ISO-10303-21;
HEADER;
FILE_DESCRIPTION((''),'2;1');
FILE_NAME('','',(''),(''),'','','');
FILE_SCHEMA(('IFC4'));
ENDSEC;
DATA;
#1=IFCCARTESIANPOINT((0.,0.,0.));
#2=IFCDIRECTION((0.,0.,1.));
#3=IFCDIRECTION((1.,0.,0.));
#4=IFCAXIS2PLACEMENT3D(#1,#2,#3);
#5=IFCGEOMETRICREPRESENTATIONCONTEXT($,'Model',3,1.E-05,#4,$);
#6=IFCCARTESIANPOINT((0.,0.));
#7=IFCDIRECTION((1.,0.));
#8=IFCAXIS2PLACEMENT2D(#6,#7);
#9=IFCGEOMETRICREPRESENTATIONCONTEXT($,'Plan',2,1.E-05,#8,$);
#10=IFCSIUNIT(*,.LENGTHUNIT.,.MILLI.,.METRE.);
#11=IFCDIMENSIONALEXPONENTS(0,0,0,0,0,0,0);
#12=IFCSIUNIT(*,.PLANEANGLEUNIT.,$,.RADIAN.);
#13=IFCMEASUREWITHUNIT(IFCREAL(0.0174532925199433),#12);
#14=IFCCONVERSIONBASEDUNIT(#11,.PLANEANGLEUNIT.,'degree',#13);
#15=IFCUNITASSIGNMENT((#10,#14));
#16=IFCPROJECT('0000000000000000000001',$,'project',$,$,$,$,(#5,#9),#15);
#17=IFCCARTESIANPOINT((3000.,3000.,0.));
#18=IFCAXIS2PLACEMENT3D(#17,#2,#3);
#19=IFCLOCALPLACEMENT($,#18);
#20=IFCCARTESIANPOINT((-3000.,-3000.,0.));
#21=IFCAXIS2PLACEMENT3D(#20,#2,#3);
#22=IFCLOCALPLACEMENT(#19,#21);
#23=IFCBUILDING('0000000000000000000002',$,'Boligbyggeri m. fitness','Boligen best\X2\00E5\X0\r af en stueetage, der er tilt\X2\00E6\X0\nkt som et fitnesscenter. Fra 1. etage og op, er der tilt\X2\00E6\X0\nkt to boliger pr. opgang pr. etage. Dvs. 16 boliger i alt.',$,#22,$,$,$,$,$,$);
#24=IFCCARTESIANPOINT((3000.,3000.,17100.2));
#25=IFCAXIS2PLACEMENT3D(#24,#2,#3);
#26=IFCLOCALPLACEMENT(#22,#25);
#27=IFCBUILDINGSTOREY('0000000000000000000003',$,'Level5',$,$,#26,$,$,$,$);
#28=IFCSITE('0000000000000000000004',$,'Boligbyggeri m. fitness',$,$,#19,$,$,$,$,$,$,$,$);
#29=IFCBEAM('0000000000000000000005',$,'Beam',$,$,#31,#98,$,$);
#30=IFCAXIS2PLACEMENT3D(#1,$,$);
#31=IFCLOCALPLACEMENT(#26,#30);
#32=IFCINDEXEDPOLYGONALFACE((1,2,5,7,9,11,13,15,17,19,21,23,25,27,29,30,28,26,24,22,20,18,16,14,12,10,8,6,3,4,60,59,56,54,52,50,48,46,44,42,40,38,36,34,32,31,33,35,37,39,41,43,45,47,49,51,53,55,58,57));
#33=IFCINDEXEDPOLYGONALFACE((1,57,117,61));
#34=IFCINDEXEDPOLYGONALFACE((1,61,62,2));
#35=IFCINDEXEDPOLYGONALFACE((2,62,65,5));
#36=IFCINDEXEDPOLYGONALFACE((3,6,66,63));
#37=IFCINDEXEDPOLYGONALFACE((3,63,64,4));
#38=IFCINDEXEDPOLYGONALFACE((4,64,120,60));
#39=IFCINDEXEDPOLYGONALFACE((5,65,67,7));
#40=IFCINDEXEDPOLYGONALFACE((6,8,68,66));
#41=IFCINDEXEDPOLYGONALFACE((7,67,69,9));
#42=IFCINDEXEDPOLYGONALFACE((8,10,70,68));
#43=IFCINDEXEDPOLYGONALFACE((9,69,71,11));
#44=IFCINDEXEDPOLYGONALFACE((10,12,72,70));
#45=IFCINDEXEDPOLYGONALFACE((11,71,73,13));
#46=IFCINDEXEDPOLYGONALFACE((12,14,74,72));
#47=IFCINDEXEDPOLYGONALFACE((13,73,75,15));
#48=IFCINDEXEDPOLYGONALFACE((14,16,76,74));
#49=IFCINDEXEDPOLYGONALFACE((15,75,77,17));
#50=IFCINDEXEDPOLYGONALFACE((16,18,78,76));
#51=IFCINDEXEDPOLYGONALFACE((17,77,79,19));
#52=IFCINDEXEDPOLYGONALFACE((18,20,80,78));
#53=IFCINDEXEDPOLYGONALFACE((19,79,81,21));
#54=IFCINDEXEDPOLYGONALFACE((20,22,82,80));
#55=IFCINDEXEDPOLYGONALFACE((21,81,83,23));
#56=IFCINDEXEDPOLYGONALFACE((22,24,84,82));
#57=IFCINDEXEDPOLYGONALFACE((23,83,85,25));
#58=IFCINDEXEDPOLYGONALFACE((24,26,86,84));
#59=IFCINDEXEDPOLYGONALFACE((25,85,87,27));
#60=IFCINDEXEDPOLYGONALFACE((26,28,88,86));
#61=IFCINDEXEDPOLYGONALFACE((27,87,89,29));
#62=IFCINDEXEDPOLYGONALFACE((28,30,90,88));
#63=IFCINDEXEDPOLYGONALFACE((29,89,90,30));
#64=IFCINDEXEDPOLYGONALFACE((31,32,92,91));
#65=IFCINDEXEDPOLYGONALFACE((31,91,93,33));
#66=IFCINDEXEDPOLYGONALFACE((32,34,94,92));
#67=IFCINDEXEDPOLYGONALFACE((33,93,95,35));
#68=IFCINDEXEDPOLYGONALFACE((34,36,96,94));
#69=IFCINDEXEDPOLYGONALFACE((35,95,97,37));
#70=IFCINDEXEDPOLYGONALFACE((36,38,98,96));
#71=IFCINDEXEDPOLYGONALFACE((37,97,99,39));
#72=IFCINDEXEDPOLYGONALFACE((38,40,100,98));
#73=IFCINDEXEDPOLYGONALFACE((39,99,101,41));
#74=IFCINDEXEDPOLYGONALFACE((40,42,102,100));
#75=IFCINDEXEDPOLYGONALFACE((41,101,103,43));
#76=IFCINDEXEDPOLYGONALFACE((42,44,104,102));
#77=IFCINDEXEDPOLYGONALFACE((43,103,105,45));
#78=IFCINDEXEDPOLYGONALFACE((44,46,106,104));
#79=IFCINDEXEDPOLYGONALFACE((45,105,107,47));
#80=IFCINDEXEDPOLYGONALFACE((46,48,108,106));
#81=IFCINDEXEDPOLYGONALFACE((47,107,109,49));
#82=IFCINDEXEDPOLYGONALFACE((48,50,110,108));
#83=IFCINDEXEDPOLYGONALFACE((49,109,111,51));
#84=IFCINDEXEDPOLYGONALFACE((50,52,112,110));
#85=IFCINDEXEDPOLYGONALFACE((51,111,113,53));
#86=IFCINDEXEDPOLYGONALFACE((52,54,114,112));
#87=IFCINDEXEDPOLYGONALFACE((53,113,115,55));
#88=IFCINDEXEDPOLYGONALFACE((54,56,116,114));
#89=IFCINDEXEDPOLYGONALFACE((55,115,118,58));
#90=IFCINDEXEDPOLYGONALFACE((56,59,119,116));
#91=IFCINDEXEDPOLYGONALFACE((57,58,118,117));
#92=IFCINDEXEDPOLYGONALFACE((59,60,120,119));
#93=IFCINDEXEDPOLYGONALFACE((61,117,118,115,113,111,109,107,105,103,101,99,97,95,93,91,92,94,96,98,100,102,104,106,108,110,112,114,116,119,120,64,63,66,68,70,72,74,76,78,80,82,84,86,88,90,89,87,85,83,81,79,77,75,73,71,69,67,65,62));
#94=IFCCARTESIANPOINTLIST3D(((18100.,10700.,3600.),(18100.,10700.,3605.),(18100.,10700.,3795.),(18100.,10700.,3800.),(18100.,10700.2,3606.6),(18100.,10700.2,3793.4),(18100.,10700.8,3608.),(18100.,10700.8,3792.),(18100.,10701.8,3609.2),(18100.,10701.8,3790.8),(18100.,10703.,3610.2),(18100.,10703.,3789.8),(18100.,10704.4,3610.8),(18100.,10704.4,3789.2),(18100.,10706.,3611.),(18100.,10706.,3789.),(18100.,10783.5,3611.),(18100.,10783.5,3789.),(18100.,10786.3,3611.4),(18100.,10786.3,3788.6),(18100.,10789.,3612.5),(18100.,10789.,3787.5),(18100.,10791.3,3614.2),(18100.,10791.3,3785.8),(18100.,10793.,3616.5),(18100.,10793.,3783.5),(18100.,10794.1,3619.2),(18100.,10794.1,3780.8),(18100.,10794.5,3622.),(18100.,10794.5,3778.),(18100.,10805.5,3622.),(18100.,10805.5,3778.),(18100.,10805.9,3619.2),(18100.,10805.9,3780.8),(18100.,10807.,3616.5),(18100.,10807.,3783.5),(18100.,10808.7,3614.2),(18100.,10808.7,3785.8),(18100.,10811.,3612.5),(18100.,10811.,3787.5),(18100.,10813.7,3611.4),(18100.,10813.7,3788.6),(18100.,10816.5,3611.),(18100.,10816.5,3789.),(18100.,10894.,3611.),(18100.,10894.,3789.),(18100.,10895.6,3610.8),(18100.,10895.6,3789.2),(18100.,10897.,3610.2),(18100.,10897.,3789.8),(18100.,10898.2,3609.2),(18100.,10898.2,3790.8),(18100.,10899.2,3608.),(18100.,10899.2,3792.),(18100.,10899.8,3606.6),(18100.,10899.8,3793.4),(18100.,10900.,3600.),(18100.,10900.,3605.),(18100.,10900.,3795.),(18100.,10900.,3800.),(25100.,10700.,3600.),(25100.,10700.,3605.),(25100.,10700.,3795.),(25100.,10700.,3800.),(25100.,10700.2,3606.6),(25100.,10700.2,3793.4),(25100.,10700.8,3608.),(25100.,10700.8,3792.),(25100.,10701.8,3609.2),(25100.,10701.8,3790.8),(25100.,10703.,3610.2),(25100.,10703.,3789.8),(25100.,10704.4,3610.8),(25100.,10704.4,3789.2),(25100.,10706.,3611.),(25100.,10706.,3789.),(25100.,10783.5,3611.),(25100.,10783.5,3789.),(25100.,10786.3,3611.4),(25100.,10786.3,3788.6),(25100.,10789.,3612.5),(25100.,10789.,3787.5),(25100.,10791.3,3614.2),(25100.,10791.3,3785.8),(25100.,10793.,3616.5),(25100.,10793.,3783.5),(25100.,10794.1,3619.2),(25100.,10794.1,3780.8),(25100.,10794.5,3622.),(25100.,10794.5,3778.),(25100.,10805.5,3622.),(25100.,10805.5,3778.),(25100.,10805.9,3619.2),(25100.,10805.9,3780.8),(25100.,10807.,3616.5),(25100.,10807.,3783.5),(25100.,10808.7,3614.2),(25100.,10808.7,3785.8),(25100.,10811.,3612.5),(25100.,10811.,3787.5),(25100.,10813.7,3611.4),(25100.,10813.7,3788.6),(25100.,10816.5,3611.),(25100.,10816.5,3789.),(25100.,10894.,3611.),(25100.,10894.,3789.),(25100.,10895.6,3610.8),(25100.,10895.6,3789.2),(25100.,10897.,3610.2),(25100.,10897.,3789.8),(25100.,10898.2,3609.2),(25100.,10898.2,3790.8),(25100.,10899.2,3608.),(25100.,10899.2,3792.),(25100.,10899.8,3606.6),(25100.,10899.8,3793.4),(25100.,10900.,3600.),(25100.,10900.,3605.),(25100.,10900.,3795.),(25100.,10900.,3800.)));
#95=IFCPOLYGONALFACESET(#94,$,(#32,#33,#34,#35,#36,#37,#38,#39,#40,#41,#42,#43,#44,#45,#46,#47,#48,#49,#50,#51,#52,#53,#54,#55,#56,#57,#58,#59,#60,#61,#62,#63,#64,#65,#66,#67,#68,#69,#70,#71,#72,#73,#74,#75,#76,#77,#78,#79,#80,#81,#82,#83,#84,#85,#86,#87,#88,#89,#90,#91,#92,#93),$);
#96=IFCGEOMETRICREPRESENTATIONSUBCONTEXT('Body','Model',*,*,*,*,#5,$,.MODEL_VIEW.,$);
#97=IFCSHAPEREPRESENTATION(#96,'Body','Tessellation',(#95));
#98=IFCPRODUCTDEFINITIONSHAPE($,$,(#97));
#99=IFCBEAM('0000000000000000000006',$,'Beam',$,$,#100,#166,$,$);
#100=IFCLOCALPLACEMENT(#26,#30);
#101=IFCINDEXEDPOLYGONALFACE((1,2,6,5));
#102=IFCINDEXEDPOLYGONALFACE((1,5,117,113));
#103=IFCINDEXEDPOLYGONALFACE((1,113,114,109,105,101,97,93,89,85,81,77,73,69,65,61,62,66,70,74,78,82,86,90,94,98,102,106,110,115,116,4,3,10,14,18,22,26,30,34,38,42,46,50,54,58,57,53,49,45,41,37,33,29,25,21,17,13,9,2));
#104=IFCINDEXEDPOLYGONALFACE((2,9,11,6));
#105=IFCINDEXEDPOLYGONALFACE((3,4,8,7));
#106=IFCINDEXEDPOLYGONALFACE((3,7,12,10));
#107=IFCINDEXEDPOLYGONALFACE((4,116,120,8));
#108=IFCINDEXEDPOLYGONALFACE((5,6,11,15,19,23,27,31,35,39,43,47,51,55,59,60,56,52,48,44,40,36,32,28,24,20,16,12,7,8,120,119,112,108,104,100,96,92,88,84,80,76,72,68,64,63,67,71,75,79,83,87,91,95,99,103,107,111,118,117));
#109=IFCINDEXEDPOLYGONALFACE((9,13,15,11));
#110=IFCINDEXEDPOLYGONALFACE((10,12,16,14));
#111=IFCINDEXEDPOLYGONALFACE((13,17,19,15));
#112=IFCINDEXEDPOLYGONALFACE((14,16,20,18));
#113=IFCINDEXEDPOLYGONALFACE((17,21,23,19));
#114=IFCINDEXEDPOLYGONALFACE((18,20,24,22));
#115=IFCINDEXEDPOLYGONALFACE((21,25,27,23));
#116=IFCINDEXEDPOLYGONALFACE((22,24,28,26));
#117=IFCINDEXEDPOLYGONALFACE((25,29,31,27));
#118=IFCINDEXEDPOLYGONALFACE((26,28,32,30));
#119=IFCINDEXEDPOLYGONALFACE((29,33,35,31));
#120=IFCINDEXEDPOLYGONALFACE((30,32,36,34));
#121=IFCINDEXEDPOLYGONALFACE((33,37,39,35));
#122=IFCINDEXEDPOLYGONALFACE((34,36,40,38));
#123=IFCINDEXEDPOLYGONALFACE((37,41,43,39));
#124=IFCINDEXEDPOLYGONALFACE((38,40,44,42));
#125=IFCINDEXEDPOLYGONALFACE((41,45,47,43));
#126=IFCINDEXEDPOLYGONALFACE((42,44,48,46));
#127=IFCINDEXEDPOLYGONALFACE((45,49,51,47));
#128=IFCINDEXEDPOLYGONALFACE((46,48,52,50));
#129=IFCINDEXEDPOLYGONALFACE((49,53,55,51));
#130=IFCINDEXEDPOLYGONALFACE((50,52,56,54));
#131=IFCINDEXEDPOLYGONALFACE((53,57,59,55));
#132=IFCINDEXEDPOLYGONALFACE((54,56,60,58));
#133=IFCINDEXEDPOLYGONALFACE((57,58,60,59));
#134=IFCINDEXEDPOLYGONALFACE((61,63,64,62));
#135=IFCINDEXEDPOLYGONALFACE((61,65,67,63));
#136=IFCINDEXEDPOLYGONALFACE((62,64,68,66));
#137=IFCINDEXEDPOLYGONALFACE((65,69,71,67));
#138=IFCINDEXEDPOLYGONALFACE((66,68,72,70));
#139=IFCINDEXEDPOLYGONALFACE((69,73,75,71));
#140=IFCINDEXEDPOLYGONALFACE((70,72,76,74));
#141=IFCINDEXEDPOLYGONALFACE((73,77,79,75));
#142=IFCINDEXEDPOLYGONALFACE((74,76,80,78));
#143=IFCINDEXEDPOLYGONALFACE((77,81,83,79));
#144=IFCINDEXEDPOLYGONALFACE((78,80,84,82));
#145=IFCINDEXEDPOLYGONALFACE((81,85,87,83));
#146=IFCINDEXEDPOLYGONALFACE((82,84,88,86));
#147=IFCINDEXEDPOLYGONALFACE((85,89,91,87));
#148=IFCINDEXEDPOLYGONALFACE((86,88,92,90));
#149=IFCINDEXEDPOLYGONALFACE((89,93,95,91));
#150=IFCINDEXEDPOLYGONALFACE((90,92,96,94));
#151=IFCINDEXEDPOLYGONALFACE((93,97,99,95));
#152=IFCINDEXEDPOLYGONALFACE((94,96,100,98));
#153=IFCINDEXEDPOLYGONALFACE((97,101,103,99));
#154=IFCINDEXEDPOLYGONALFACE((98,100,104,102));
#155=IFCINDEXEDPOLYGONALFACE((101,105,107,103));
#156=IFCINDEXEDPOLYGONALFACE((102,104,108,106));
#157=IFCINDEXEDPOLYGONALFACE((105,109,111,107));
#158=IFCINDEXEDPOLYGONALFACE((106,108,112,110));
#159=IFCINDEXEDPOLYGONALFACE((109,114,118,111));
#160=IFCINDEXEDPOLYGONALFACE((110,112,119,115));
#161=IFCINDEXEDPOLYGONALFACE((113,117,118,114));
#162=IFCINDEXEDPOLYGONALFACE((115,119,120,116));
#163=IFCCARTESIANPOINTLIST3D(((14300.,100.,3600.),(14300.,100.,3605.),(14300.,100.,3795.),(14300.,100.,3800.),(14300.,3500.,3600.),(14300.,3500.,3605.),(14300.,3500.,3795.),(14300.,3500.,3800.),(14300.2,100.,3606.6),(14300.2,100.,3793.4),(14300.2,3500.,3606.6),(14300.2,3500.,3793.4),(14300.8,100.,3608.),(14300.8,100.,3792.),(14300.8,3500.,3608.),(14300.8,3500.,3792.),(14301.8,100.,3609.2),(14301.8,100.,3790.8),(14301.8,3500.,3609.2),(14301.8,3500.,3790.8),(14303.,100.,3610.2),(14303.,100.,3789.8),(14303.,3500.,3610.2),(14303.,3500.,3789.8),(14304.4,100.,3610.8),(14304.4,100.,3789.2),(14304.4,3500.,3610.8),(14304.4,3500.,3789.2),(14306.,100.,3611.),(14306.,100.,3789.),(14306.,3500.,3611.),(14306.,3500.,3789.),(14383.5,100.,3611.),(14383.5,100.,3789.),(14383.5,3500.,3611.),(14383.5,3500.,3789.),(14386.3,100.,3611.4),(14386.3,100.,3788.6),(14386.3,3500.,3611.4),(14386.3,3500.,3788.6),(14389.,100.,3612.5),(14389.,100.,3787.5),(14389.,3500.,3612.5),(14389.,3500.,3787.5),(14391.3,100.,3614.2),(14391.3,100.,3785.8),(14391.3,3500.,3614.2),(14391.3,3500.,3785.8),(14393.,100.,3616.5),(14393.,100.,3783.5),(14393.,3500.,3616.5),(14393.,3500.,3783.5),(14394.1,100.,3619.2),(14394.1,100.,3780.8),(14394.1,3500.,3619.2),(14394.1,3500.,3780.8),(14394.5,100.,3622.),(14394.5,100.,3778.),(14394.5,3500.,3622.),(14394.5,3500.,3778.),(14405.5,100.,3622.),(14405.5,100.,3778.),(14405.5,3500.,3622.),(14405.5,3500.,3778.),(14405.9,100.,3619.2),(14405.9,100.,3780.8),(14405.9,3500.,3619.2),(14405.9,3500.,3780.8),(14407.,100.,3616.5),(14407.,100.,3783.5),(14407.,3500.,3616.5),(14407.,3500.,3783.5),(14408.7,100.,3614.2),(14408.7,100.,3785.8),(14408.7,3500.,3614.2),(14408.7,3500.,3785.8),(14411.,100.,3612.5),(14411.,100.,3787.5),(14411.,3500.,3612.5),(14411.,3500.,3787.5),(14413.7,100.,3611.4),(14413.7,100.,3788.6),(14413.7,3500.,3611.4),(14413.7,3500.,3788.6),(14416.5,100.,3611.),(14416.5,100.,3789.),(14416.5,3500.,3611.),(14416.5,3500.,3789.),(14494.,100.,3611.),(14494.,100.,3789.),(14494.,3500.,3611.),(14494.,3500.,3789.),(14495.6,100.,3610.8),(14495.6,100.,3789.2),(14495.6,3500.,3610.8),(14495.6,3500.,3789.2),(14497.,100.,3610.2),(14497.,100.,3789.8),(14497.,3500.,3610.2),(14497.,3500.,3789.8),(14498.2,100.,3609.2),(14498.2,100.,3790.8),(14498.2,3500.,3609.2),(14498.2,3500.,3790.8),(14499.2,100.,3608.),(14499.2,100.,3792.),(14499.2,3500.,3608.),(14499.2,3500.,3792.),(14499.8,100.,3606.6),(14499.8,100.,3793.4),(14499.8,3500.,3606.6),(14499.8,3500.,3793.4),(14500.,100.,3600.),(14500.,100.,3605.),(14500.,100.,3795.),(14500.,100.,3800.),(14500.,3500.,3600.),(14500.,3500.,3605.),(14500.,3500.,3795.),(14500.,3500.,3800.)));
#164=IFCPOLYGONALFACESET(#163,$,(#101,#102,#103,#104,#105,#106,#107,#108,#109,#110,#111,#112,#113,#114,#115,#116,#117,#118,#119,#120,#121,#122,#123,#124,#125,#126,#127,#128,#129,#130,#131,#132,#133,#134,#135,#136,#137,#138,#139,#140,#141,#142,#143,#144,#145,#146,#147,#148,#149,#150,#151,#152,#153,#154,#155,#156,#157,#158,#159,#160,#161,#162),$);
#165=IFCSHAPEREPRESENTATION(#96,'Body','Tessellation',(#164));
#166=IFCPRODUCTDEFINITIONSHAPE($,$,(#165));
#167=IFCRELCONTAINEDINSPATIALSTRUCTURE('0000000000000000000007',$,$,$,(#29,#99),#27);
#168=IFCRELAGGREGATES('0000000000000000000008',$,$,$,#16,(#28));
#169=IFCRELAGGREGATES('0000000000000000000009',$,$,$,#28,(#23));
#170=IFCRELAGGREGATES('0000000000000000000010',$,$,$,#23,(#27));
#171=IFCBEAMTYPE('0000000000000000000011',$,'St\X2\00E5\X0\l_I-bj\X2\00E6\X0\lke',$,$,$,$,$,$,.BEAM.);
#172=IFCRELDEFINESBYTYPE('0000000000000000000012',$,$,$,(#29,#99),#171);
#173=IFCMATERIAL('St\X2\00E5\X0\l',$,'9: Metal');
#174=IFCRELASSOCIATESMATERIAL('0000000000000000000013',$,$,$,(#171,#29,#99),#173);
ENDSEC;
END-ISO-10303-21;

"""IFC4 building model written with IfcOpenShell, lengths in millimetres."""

from ifc_helpers import new_model, entity, si_unit, converted_unit, frame, origin_with_axes, origin_2d_with_axis, place, context, subcontext, project, spatial, i_section, extrude, material, material_profile, profile_set, profile_usage, type_object, element, save


model = new_model("IFC4")

# Units and contexts
model_context = context("Model", 3, precision=1e-05, world=origin_with_axes())
plan_context = context("Plan", 2, precision=1e-05, world=origin_2d_with_axis())
body_context = subcontext(model_context, "Body", "Model", "MODEL_VIEW")
ifc_project = project(units=[si_unit("LENGTHUNIT", "METRE", prefix="MILLI"), converted_unit("PLANEANGLEUNIT", "degree", entity("IfcReal", 0.0174532925199433), si_unit("PLANEANGLEUNIT", "RADIAN"), dimensions=[0, 0, 0, 0, 0, 0, 0])], contexts=[model_context, plan_context])

# Site, building, storey
site_placement = place(None, frame((3000.0, 3000.0, 0.0), z_axis=(0.0, 0.0, 1.0), x_axis=(1.0, 0.0, 0.0)))
site = spatial("IfcSite", under=ifc_project, at=site_placement, Name="Boligbyggeri m. fitness")
building_placement = place(site_placement, frame((-3000.0, -3000.0, 0.0), z_axis=(0.0, 0.0, 1.0), x_axis=(1.0, 0.0, 0.0)))
building = spatial("IfcBuilding", under=site, at=building_placement, Name="Boligbyggeri m. fitness", Description="Boligen består af en stueetage, der er tiltænkt som et fitnesscenter. Fra 1. etage og op, er der tiltænkt to boliger pr. opgang pr. etage. Dvs. 16 boliger i alt.")
storey_placement = place(building_placement, frame((3000.0, 3000.0, 17100.2), z_axis=(0.0, 0.0, 1.0), x_axis=(1.0, 0.0, 0.0)))
storey = spatial("IfcBuildingStorey", under=building, at=storey_placement, Name="Level5")

# Beams
ifc_material_1 = material(Name="Stål", Category="9: Metal")
ifc_material_profile_1 = material_profile(ifc_material_1, i_section(OverallWidth=200.0, OverallDepth=200.0, WebThickness=11.0, FlangeThickness=11.0, FilletRadius=11.0, FlangeEdgeRadius=6.0), Name="Stål", Category="9: Metal")
ifc_profile_set_1 = profile_set([ifc_material_profile_1], Name="NY_I-Profil")
beam_type = type_object("IfcBeamType", Name="Stål_I-bjælke", PredefinedType="BEAM", material=ifc_profile_set_1)
ifc_profile_usage_1 = profile_usage(ifc_profile_set_1, cardinal=7)
beam_1_placement = place(storey_placement, frame((18100.0, 10900.0, 3800.0), z_axis=(1.0, 0.0, 0.0), x_axis=(0.0, 1.0, 0.0)))
element("IfcBeam", 1, at=beam_1_placement, inside=storey, type_object=beam_type, material=ifc_profile_usage_1, Name="Beam", context=body_context, shape_type="SweptSolid", body=[
    extrude(i_section(OverallWidth=200.0, OverallDepth=200.0, WebThickness=11.0, FlangeThickness=11.0, FilletRadius=11.0, FlangeEdgeRadius=6.0), frame((-100.0, -100.0, 0.0), z_axis=(0.0, 0.0, 1.0), x_axis=(1.0, 0.0, 0.0)), (0.0, 0.0, 1.0), 7000.0),
])
ifc_profile_usage_2 = profile_usage(ifc_profile_set_1, cardinal=9)
beam_2_placement = place(storey_placement, frame((14500.0, 100.0, 3800.0), z_axis=(0.0, 1.0, 0.0), x_axis=(-1.0, 0.0, 0.0)))
element("IfcBeam", 2, at=beam_2_placement, inside=storey, type_object=beam_type, material=ifc_profile_usage_2, Name="Beam", context=body_context, shape_type="SweptSolid", body=[
    extrude(i_section(OverallWidth=200.0, OverallDepth=200.0, WebThickness=11.0, FlangeThickness=11.0, FilletRadius=11.0, FlangeEdgeRadius=6.0), frame((100.0, -100.0, 0.0), z_axis=(0.0, 0.0, 1.0), x_axis=(1.0, 0.0, 0.0)), (0.0, 0.0, 1.0), 3400.0),
])

save(model, "model.ifc")
